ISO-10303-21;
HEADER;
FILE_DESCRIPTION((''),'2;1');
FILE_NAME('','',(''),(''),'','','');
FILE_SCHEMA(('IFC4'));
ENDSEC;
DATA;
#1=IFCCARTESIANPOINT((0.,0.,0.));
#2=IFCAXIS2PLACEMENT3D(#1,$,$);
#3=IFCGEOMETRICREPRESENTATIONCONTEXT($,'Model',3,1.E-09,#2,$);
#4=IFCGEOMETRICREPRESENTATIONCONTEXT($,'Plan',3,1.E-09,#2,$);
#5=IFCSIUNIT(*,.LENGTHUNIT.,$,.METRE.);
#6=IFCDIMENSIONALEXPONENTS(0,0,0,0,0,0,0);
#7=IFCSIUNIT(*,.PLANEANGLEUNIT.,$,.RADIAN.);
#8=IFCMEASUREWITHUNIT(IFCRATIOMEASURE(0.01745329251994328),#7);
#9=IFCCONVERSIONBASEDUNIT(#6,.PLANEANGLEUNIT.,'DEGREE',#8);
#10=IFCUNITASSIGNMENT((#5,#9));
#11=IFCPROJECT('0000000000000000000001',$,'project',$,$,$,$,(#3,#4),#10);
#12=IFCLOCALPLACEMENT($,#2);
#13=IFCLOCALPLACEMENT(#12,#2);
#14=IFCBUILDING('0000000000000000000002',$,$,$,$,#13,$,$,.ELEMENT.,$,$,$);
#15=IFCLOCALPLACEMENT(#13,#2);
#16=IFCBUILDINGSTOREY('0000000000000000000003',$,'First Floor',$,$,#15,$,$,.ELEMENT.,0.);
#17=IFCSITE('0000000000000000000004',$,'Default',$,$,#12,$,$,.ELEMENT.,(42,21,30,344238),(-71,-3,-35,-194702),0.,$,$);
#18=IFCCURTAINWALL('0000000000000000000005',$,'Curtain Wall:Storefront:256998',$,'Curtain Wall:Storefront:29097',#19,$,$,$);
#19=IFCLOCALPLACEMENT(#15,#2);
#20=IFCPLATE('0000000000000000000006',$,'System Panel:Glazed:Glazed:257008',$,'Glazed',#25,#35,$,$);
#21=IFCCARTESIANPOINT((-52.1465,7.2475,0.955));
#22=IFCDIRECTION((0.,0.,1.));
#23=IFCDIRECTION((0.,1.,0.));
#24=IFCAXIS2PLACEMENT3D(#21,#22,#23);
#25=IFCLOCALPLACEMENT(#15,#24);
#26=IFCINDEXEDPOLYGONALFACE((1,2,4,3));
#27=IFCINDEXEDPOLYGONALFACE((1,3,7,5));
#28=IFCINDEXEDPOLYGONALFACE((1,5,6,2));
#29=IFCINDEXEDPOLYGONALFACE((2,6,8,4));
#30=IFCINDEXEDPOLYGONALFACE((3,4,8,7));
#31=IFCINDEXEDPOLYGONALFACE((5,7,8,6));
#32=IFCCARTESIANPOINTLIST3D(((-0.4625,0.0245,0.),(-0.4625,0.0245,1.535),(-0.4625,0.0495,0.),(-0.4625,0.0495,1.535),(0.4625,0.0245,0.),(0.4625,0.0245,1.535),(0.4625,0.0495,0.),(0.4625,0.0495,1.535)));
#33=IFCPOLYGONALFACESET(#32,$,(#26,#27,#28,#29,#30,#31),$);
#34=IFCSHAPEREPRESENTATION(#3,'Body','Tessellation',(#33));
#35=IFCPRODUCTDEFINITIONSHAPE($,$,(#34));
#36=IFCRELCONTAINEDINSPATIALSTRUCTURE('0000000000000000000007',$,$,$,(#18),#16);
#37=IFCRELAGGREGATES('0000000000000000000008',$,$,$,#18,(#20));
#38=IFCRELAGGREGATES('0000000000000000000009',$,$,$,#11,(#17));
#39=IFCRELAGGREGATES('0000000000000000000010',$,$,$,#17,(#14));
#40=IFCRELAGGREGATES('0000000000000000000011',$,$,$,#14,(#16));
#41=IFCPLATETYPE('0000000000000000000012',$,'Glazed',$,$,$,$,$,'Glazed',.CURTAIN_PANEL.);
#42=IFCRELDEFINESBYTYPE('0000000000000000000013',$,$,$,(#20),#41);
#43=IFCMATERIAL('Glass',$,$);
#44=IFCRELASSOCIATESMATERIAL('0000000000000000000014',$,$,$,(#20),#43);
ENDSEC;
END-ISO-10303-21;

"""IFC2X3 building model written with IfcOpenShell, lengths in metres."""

from ifc_helpers import new_model, entity, si_unit, converted_unit, frame, origin, origin_2d_with_axis, place, context, project, spatial, rectangle, extrude, source, transform, mapped, material, type_object, type_shapes, element, aggregate, save


model = new_model("IFC2X3")

# Units and contexts
model_context = context("Model", 3, precision=1e-09, world=origin())
plan_context = context("Plan", 3, precision=1e-09, world=origin())
ifc_project = project(units=[si_unit("LENGTHUNIT", "METRE"), converted_unit("PLANEANGLEUNIT", "DEGREE", entity("IfcRatioMeasure", 0.01745329251994328), si_unit("PLANEANGLEUNIT", "RADIAN"), dimensions=[0, 0, 0, 0, 0, 0, 0])], contexts=[model_context, plan_context])

# Site, building, storey
site_placement = place(None, origin())
site = spatial("IfcSite", under=ifc_project, at=site_placement, Name="Default", CompositionType="ELEMENT", RefLatitude=(42, 21, 30, 344238), RefLongitude=(-71, -3, -35, -194702), RefElevation=0.0)
building_placement = place(site_placement, origin())
building = spatial("IfcBuilding", under=site, at=building_placement, CompositionType="ELEMENT")
storey_placement = place(building_placement, origin())
storey = spatial("IfcBuildingStorey", under=building, at=storey_placement, Name="First Floor", CompositionType="ELEMENT", Elevation=0.0)

# Curtain wall, plate
curtain_wall_placement = place(storey_placement, origin())
curtain_wall = element("IfcCurtainWall", 1, at=curtain_wall_placement, inside=storey, Name="Curtain Wall:Storefront:256998", ObjectType="Curtain Wall:Storefront:29097")
ifc_material_1 = material(Name="Glass")
plate_type = type_object("IfcPlateType", Name="Glazed", ElementType="Glazed", PredefinedType="CURTAIN_PANEL")
shared_shape_1 = source(origin(), model_context, "Body", "SweptSolid", [
    extrude(rectangle(XDim=0.025, YDim=0.925, at=origin_2d_with_axis()), frame((0.0, 0.037, 0.0), z_axis=(0.0, 0.0, 1.0), x_axis=(0.0, 1.0, 0.0)), (0.0, 0.0, 1.0), 1.535),
])
type_shapes(plate_type, [shared_shape_1])
plate_placement = place(storey_placement, frame((-52.1465, 7.2475, 0.955), z_axis=(0.0, 0.0, 1.0), x_axis=(0.0, 1.0, 0.0)))
plate = element("IfcPlate", 2, at=plate_placement, type_object=plate_type, material=ifc_material_1, Name="System Panel:Glazed:Glazed:257008", ObjectType="Glazed", context=model_context, shape_type="MappedRepresentation", body=[
    mapped(shared_shape_1, transform((0.0, 0.0, 0.0), scale=1.0)),
])
aggregate(curtain_wall, [plate])

save(model, "model.ifc")
